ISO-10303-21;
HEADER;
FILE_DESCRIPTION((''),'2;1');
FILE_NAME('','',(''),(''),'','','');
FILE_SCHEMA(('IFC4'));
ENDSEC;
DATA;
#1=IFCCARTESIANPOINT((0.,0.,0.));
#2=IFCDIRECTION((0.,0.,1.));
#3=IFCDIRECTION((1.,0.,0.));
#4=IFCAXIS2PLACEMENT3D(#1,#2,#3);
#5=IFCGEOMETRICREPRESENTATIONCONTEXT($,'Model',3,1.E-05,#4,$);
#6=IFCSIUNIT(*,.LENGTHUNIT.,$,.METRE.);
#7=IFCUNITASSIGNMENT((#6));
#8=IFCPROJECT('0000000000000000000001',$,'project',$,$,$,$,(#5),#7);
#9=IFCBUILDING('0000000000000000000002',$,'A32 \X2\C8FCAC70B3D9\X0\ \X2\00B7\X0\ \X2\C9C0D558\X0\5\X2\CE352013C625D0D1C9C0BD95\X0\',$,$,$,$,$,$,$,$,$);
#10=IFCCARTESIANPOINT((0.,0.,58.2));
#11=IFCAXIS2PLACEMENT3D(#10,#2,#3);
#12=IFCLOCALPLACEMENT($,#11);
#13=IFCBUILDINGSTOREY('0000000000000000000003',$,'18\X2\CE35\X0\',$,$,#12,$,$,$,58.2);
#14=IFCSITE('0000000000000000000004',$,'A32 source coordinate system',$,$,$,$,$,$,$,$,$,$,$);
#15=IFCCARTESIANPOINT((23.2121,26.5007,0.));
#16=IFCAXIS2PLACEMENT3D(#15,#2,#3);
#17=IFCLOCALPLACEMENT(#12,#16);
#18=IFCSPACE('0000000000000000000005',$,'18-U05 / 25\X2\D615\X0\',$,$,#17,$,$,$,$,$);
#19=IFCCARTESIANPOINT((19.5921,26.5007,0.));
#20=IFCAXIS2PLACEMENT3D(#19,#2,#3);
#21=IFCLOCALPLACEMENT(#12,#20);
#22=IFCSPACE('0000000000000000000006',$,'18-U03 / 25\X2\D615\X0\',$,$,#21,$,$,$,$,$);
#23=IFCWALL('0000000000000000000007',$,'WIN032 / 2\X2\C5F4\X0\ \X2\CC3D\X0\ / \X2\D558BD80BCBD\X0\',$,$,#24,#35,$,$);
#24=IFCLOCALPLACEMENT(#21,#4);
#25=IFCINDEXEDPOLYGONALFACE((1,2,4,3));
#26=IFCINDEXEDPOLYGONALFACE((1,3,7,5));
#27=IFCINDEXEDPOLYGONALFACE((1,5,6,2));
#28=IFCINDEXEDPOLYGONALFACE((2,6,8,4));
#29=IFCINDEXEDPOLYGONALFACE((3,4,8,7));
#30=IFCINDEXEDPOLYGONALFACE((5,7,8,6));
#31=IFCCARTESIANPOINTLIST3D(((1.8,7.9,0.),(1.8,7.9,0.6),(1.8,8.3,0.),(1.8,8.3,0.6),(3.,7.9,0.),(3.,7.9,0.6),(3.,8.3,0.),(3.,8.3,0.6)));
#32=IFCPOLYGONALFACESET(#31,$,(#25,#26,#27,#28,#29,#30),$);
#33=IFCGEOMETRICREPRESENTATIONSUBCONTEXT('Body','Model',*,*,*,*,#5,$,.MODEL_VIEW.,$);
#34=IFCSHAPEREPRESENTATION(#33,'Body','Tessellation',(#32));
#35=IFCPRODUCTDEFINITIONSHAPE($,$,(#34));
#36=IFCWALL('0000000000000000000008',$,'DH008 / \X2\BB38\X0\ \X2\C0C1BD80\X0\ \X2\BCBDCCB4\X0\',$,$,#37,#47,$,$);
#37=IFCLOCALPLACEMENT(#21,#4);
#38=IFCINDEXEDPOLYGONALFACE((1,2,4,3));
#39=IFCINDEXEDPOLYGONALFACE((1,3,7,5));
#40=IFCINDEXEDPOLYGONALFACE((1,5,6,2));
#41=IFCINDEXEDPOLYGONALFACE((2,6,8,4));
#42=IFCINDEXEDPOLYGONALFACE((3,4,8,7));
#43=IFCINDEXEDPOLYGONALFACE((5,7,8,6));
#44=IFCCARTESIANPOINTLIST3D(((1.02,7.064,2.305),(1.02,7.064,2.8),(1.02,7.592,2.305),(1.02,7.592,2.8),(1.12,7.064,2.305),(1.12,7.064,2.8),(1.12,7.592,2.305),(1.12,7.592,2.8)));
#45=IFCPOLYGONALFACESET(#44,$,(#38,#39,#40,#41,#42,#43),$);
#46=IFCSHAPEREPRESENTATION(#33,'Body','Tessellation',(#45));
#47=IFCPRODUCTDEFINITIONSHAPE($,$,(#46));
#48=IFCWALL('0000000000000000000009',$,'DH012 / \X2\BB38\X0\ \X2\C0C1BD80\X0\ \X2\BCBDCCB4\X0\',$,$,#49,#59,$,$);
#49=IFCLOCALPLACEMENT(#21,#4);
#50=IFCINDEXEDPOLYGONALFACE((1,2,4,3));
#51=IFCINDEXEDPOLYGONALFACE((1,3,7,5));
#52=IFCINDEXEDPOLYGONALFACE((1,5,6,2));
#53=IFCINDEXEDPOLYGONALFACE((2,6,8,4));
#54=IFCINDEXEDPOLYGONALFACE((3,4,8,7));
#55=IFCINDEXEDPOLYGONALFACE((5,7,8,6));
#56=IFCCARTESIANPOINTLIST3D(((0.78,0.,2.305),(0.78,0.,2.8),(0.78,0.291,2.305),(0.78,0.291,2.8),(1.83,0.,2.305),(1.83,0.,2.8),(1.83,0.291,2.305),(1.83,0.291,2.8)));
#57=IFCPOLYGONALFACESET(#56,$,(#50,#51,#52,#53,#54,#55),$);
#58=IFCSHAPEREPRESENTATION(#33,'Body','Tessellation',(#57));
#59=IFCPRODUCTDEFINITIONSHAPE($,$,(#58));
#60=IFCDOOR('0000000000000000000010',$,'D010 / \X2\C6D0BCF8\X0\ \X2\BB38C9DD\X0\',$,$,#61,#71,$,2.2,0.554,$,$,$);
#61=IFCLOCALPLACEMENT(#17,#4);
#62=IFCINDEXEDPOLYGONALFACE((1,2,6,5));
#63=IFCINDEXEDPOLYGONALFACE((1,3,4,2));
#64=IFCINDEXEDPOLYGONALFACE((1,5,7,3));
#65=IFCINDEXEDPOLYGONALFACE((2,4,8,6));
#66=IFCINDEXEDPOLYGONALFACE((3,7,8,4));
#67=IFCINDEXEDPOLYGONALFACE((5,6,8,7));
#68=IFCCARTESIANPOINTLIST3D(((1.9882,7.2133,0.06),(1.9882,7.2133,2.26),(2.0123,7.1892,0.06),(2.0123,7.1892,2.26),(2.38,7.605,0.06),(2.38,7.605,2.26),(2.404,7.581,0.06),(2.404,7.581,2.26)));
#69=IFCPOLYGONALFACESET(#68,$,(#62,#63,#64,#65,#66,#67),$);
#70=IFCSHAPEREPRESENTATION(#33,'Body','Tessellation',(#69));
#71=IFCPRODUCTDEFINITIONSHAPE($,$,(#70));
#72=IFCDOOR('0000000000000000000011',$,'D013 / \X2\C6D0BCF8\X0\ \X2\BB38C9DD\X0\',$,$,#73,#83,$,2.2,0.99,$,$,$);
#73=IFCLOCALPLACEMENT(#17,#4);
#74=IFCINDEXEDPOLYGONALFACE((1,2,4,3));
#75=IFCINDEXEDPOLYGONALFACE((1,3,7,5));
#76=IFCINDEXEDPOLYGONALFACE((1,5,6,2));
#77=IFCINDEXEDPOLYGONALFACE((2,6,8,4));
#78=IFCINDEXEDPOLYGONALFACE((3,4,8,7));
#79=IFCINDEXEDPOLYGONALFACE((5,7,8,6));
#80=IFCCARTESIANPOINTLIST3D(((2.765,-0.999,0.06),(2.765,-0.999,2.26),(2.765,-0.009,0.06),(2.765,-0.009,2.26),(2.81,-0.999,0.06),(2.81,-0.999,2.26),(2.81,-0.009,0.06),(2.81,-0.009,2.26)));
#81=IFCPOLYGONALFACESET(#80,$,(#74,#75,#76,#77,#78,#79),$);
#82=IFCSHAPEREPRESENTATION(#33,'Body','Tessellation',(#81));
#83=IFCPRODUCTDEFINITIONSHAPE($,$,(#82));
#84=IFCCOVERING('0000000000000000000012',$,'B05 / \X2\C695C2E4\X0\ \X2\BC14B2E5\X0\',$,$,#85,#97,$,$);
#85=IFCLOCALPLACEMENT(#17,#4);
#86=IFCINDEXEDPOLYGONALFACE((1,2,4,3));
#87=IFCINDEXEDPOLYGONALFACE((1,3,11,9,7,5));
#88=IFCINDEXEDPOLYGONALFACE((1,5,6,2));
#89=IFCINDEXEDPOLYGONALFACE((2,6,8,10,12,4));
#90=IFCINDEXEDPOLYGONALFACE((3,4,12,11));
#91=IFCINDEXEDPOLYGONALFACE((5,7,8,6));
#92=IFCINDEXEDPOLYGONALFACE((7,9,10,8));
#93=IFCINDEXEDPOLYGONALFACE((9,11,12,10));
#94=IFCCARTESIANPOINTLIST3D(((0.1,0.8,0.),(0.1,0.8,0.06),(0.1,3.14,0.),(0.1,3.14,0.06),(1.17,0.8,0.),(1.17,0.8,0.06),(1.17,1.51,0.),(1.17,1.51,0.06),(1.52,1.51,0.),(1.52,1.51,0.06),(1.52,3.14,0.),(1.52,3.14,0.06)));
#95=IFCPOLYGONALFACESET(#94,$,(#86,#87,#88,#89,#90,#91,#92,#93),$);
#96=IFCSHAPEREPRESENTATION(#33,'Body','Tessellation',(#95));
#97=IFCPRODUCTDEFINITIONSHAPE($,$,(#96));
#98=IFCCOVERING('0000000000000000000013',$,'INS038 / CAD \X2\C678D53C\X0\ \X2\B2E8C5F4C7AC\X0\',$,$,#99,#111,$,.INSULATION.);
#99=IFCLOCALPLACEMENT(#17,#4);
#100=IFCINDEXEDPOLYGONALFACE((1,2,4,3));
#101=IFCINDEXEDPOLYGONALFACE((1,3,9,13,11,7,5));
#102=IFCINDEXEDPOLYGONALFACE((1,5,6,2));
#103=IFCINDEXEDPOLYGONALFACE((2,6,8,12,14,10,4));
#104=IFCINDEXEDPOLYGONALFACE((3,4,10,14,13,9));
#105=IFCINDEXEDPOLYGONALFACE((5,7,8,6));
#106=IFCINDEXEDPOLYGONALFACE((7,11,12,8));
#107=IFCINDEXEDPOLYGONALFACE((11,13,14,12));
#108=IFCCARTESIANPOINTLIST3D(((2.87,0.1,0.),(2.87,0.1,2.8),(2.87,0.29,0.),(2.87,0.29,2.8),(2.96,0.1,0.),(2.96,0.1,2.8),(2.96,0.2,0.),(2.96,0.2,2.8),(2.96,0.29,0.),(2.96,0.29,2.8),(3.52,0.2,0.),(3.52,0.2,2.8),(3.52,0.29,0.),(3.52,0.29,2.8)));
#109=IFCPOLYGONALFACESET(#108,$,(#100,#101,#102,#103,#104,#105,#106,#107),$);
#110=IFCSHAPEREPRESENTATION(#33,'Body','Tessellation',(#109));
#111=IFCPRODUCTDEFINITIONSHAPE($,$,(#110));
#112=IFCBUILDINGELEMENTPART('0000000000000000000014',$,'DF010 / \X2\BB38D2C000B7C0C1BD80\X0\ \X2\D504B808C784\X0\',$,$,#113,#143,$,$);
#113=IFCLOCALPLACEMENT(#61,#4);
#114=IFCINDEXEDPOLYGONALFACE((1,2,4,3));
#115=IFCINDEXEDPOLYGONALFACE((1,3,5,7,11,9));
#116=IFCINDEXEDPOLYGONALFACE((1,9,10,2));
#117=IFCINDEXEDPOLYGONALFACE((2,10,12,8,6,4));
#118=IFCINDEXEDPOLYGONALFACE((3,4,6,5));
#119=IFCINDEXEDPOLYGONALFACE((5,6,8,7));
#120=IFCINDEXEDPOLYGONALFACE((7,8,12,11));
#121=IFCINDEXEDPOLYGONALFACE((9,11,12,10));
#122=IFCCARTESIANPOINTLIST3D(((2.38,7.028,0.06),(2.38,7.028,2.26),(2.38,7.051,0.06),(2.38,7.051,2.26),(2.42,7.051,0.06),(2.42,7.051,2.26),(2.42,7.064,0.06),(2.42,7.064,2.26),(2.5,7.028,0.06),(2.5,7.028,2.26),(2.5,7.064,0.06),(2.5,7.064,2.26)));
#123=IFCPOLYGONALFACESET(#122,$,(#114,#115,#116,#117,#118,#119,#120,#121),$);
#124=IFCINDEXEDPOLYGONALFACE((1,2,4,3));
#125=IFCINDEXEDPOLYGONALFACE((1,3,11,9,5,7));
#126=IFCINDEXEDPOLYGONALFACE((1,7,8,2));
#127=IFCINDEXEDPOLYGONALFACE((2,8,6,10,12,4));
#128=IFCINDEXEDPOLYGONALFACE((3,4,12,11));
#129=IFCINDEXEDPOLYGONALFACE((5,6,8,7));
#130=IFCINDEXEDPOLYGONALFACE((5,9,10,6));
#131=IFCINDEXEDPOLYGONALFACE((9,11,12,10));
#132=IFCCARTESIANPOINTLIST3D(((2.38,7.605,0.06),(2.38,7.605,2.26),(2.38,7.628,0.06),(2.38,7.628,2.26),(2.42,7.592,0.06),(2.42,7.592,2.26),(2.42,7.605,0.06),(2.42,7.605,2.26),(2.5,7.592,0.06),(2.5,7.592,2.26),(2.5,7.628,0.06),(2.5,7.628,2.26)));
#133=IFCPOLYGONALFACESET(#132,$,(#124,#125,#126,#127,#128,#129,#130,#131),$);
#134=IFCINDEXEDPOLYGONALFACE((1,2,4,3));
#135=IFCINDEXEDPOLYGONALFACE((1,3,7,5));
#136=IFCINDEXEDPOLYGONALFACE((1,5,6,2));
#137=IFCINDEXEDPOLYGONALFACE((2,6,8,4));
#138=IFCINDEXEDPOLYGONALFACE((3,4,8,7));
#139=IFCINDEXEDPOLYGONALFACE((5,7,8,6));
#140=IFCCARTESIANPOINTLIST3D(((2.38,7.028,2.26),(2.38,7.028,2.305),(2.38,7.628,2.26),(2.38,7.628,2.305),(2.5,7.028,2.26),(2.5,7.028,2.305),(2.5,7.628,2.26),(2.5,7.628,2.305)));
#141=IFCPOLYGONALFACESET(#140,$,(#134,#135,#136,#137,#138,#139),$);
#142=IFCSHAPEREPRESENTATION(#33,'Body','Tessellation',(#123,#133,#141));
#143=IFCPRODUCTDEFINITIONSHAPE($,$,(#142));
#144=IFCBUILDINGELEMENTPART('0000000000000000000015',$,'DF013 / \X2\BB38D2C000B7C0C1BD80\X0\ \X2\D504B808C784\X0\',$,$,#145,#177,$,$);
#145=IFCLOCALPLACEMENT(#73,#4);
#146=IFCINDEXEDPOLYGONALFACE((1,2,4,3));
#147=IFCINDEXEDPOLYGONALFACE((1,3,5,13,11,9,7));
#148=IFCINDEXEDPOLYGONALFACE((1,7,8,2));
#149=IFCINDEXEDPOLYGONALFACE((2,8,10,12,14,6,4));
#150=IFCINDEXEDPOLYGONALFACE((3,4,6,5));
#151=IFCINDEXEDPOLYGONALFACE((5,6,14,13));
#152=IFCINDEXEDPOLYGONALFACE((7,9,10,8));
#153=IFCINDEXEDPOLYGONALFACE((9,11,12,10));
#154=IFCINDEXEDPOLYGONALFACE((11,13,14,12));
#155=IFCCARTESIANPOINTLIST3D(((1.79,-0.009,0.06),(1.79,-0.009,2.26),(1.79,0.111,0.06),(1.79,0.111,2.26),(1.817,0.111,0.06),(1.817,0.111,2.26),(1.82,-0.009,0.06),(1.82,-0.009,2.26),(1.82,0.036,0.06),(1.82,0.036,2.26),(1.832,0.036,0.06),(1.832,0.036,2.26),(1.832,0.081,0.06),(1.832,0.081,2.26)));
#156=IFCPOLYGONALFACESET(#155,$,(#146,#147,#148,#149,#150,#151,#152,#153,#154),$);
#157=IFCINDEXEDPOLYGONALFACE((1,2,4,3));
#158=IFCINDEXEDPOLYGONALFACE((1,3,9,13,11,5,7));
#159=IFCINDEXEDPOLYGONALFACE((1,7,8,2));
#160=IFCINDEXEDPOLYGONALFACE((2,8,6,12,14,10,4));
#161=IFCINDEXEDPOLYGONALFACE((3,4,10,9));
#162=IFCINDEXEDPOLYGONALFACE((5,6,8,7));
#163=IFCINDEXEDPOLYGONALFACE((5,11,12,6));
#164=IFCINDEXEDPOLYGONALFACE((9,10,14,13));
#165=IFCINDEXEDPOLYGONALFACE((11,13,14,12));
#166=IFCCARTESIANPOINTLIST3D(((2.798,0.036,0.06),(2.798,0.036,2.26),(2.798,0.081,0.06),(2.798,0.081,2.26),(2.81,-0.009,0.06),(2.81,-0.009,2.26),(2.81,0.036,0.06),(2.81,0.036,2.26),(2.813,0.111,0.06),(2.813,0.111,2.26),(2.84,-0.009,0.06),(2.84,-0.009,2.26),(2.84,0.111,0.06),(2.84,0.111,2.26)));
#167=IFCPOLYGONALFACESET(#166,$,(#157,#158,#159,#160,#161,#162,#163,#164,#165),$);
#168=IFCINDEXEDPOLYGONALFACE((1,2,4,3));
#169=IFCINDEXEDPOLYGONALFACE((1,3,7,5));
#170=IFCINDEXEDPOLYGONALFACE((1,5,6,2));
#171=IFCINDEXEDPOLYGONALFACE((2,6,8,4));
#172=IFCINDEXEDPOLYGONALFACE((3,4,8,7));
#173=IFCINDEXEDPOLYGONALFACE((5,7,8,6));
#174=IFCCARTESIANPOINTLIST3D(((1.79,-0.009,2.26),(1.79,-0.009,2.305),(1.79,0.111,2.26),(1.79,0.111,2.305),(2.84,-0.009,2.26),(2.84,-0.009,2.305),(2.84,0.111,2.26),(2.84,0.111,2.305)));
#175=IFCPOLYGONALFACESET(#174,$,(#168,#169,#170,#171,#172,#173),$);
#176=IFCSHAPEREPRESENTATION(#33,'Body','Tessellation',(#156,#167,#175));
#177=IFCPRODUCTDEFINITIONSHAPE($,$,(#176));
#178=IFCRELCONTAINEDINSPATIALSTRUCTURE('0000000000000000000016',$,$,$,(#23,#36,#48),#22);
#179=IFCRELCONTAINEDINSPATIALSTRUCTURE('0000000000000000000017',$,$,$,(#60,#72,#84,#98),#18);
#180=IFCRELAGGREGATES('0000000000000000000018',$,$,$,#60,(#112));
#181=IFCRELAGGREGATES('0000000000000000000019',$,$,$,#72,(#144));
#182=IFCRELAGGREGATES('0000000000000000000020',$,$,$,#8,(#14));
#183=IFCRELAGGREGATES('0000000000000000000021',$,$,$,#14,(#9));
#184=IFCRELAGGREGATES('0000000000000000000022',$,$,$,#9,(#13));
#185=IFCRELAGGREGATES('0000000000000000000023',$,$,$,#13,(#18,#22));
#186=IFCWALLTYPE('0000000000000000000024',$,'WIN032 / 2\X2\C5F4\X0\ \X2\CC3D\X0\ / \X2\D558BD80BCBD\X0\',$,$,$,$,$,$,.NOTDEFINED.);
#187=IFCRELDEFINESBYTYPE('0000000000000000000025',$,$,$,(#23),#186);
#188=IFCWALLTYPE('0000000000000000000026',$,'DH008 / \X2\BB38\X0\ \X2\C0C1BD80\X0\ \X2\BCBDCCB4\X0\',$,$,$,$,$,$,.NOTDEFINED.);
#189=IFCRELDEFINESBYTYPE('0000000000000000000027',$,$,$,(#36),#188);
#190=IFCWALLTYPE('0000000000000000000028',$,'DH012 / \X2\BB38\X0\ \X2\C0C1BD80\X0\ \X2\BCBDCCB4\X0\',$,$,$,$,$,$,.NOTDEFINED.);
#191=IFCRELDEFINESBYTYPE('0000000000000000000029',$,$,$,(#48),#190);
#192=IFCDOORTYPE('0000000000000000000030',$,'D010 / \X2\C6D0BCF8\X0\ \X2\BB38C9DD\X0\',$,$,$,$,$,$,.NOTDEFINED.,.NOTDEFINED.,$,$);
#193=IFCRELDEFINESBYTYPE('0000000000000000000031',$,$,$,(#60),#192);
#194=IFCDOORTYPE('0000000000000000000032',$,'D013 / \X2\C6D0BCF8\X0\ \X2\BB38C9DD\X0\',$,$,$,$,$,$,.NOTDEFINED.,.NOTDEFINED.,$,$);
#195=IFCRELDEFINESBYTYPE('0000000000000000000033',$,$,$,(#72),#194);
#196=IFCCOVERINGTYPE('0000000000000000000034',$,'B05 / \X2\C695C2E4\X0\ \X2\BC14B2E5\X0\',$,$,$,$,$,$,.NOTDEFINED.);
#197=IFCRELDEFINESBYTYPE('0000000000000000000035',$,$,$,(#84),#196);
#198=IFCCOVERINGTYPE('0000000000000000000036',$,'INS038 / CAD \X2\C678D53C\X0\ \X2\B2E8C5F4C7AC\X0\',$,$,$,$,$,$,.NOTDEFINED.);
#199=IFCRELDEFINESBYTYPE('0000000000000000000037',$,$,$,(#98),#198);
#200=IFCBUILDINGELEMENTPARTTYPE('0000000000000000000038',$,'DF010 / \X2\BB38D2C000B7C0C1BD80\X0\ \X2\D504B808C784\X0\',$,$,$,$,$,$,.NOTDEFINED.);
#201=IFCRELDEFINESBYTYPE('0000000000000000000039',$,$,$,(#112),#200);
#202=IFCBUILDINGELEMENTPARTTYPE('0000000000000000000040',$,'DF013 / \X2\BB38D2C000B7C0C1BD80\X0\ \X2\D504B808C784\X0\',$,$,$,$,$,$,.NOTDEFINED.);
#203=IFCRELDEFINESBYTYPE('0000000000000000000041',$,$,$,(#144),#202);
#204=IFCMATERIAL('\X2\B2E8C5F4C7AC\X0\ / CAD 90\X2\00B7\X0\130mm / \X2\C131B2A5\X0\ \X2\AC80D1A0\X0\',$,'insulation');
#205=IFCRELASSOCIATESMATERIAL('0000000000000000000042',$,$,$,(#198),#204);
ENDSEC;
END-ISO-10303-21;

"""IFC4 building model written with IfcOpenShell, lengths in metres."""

from ifc_helpers import new_model, si_unit, frame, origin, origin_with_axes, place, context, subcontext, project, spatial, polyline, outline, extrude, source, transform, mapped, material, type_object, type_shapes, element, aggregate, save


model = new_model("IFC4")

# Units and contexts
model_context = context("Model", 3, precision=1e-05, world=origin_with_axes())
body_context = subcontext(model_context, "Body", "Model", "MODEL_VIEW")
ifc_project = project(units=[si_unit("LENGTHUNIT", "METRE")], contexts=[model_context])

# Site, building, storey, space
storey_placement = place(None, frame((0.0, 0.0, 58.2), z_axis=(0.0, 0.0, 1.0), x_axis=(1.0, 0.0, 0.0)))
space_1_placement = place(storey_placement, frame((23.2121, 26.5007, 0.0), z_axis=(0.0, 0.0, 1.0), x_axis=(1.0, 0.0, 0.0)))
site = spatial("IfcSite", under=ifc_project, Name="A32 source coordinate system")
building = spatial("IfcBuilding", under=site, Name="A32 주거동 · 지하5층–옥탑지붕")
storey = spatial("IfcBuildingStorey", under=building, at=storey_placement, Name="18층", Elevation=58.2)
space_1 = spatial("IfcSpace", under=storey, at=space_1_placement, Name="18-U05 / 25형")

# Shared definitions
space_2_placement = place(storey_placement, frame((19.5921, 26.5007, 0.0), z_axis=(0.0, 0.0, 1.0), x_axis=(1.0, 0.0, 0.0)))
space_2 = spatial("IfcSpace", under=storey, at=space_2_placement, Name="18-U03 / 25형")

# Walls
wall_type_1 = type_object("IfcWallType", Name="WIN032 / 2열 창 / 하부벽", PredefinedType="NOTDEFINED")
shared_shape_1 = source(origin(), body_context, "Body", "SweptSolid", [
    extrude(outline(polyline([(3.0, 7.9), (1.8, 7.9), (1.8, 8.3), (3.0, 8.3), (3.0, 7.9)])), origin(), (0.0, 0.0, 1.0), 0.6),
])
type_shapes(wall_type_1, [shared_shape_1])
wall_1_placement = place(space_2_placement, origin_with_axes())
element("IfcWall", 1, at=wall_1_placement, inside=space_2, type_object=wall_type_1, Name="WIN032 / 2열 창 / 하부벽", context=body_context, shape_type="MappedRepresentation", body=[
    mapped(shared_shape_1, transform((0.0, 0.0, 0.0), scale=1.0)),
])
wall_type_2 = type_object("IfcWallType", Name="DH008 / 문 상부 벽체", PredefinedType="NOTDEFINED")
shared_shape_2 = source(origin(), body_context, "Body", "SweptSolid", [
    extrude(outline(polyline([(1.12, 7.064), (1.02, 7.064), (1.02, 7.592), (1.12, 7.592), (1.12, 7.064)])), frame((0.0, 0.0, 2.305)), (0.0, 0.0, 1.0), 0.495),
])
type_shapes(wall_type_2, [shared_shape_2])
wall_2_placement = place(space_2_placement, origin_with_axes())
element("IfcWall", 2, at=wall_2_placement, inside=space_2, type_object=wall_type_2, Name="DH008 / 문 상부 벽체", context=body_context, shape_type="MappedRepresentation", body=[
    mapped(shared_shape_2, transform((0.0, 0.0, 0.0), scale=1.0)),
])
wall_type_3 = type_object("IfcWallType", Name="DH012 / 문 상부 벽체", PredefinedType="NOTDEFINED")
shared_shape_3 = source(origin(), body_context, "Body", "SweptSolid", [
    extrude(outline(polyline([(0.78, 0.0), (0.78, 0.291), (1.83, 0.291), (1.83, 0.0), (0.78, 0.0)])), frame((0.0, 0.0, 2.305)), (0.0, 0.0, 1.0), 0.495),
])
type_shapes(wall_type_3, [shared_shape_3])
wall_3_placement = place(space_2_placement, origin_with_axes())
element("IfcWall", 3, at=wall_3_placement, inside=space_2, type_object=wall_type_3, Name="DH012 / 문 상부 벽체", context=body_context, shape_type="MappedRepresentation", body=[
    mapped(shared_shape_3, transform((0.0, 0.0, 0.0), scale=1.0)),
])

# Doors
door_type_1 = type_object("IfcDoorType", Name="D010 / 원본 문짝", OperationType="NOTDEFINED", PredefinedType="NOTDEFINED")
shared_shape_4 = source(origin(), body_context, "Body", "SweptSolid", [
    extrude(outline(polyline([(2.0123, 7.1892), (1.9882, 7.2133), (2.38, 7.605), (2.404, 7.581), (2.0123, 7.1892)])), frame((0.0, 0.0, 0.06)), (0.0, 0.0, 1.0), 2.2),
])
type_shapes(door_type_1, [shared_shape_4])
door_1_placement = place(space_1_placement, origin_with_axes())
door_1 = element("IfcDoor", 4, at=door_1_placement, inside=space_1, type_object=door_type_1, Name="D010 / 원본 문짝", OverallHeight=2.2, OverallWidth=0.554, context=body_context, shape_type="MappedRepresentation", body=[
    mapped(shared_shape_4, transform((0.0, 0.0, 0.0), scale=1.0)),
])
door_type_2 = type_object("IfcDoorType", Name="D013 / 원본 문짝", OperationType="NOTDEFINED", PredefinedType="NOTDEFINED")
shared_shape_5 = source(origin(), body_context, "Body", "SweptSolid", [
    extrude(outline(polyline([(2.81, -0.009), (2.81, -0.999), (2.765, -0.999), (2.765, -0.009), (2.81, -0.009)])), frame((0.0, 0.0, 0.06)), (0.0, 0.0, 1.0), 2.2),
])
type_shapes(door_type_2, [shared_shape_5])
door_2_placement = place(space_1_placement, origin_with_axes())
door_2 = element("IfcDoor", 5, at=door_2_placement, inside=space_1, type_object=door_type_2, Name="D013 / 원본 문짝", OverallHeight=2.2, OverallWidth=0.99, context=body_context, shape_type="MappedRepresentation", body=[
    mapped(shared_shape_5, transform((0.0, 0.0, 0.0), scale=1.0)),
])

# Coverings
covering_type_1 = type_object("IfcCoveringType", Name="B05 / 욕실 바닥", PredefinedType="NOTDEFINED")
shared_shape_6 = source(origin(), body_context, "Body", "SweptSolid", [
    extrude(outline(polyline([(0.1, 3.14), (1.52, 3.14), (1.52, 1.51), (1.17, 1.51), (1.17, 0.8), (0.1, 0.8), (0.1, 3.14)])), origin(), (0.0, 0.0, 1.0), 0.06),
])
type_shapes(covering_type_1, [shared_shape_6])
covering_1_placement = place(space_1_placement, origin_with_axes())
element("IfcCovering", 6, at=covering_1_placement, inside=space_1, type_object=covering_type_1, Name="B05 / 욕실 바닥", context=body_context, shape_type="MappedRepresentation", body=[
    mapped(shared_shape_6, transform((0.0, 0.0, 0.0), scale=1.0)),
])
ifc_material = material(Name="단열재 / CAD 90·130mm / 성능 검토", Category="insulation")
covering_type_2 = type_object("IfcCoveringType", Name="INS038 / CAD 외피 단열재", PredefinedType="NOTDEFINED", material=ifc_material)
shared_shape_7 = source(origin(), body_context, "Body", "SweptSolid", [
    extrude(outline(polyline([(2.96, 0.2), (2.96, 0.1), (2.87, 0.1), (2.87, 0.29), (2.96, 0.29), (3.52, 0.29), (3.52, 0.2), (2.96, 0.2)])), origin(), (0.0, 0.0, 1.0), 2.8),
])
type_shapes(covering_type_2, [shared_shape_7])
covering_2_placement = place(space_1_placement, origin_with_axes())
element("IfcCovering", 7, at=covering_2_placement, inside=space_1, type_object=covering_type_2, Name="INS038 / CAD 외피 단열재", PredefinedType="INSULATION", context=body_context, shape_type="MappedRepresentation", body=[
    mapped(shared_shape_7, transform((0.0, 0.0, 0.0), scale=1.0)),
])

# Building element parts
building_element_part_type_1 = type_object("IfcBuildingElementPartType", Name="DF010 / 문틀·상부 프레임", PredefinedType="NOTDEFINED")
shared_shape_8 = source(origin(), body_context, "Body", "SweptSolid", [
    extrude(outline(polyline([(2.38, 7.028), (2.38, 7.051), (2.42, 7.051), (2.42, 7.064), (2.5, 7.064), (2.5, 7.028), (2.38, 7.028)])), frame((0.0, 0.0, 0.06)), (0.0, 0.0, 1.0), 2.2),
    extrude(outline(polyline([(2.5, 7.592), (2.42, 7.592), (2.42, 7.605), (2.38, 7.605), (2.38, 7.628), (2.5, 7.628), (2.5, 7.592)])), frame((0.0, 0.0, 0.06)), (0.0, 0.0, 1.0), 2.2),
    extrude(outline(polyline([(2.38, 7.028), (2.38, 7.628), (2.5, 7.628), (2.5, 7.028), (2.38, 7.028)])), frame((0.0, 0.0, 2.26)), (0.0, 0.0, 1.0), 0.045),
])
type_shapes(building_element_part_type_1, [shared_shape_8])
building_element_part_1_placement = place(door_1_placement, origin_with_axes())
building_element_part_1 = element("IfcBuildingElementPart", 8, at=building_element_part_1_placement, type_object=building_element_part_type_1, Name="DF010 / 문틀·상부 프레임", context=body_context, shape_type="MappedRepresentation", body=[
    mapped(shared_shape_8, transform((0.0, 0.0, 0.0), scale=1.0)),
])
aggregate(door_1, [building_element_part_1])
building_element_part_type_2 = type_object("IfcBuildingElementPartType", Name="DF013 / 문틀·상부 프레임", PredefinedType="NOTDEFINED")
shared_shape_9 = source(origin(), body_context, "Body", "SweptSolid", [
    extrude(outline(polyline([(1.79, 0.111), (1.817, 0.111), (1.832, 0.081), (1.832, 0.036), (1.82, 0.036), (1.82, -0.009), (1.79, -0.009), (1.79, 0.111)])), frame((0.0, 0.0, 0.06)), (0.0, 0.0, 1.0), 2.2),
    extrude(outline(polyline([(2.81, -0.009), (2.81, 0.036), (2.798, 0.036), (2.798, 0.081), (2.813, 0.111), (2.84, 0.111), (2.84, -0.009), (2.81, -0.009)])), frame((0.0, 0.0, 0.06)), (0.0, 0.0, 1.0), 2.2),
    extrude(outline(polyline([(1.79, -0.009), (1.79, 0.111), (2.84, 0.111), (2.84, -0.009), (1.79, -0.009)])), frame((0.0, 0.0, 2.26)), (0.0, 0.0, 1.0), 0.045),
])
type_shapes(building_element_part_type_2, [shared_shape_9])
building_element_part_2_placement = place(door_2_placement, origin_with_axes())
building_element_part_2 = element("IfcBuildingElementPart", 9, at=building_element_part_2_placement, type_object=building_element_part_type_2, Name="DF013 / 문틀·상부 프레임", context=body_context, shape_type="MappedRepresentation", body=[
    mapped(shared_shape_9, transform((0.0, 0.0, 0.0), scale=1.0)),
])
aggregate(door_2, [building_element_part_2])

save(model, "model.ifc")
